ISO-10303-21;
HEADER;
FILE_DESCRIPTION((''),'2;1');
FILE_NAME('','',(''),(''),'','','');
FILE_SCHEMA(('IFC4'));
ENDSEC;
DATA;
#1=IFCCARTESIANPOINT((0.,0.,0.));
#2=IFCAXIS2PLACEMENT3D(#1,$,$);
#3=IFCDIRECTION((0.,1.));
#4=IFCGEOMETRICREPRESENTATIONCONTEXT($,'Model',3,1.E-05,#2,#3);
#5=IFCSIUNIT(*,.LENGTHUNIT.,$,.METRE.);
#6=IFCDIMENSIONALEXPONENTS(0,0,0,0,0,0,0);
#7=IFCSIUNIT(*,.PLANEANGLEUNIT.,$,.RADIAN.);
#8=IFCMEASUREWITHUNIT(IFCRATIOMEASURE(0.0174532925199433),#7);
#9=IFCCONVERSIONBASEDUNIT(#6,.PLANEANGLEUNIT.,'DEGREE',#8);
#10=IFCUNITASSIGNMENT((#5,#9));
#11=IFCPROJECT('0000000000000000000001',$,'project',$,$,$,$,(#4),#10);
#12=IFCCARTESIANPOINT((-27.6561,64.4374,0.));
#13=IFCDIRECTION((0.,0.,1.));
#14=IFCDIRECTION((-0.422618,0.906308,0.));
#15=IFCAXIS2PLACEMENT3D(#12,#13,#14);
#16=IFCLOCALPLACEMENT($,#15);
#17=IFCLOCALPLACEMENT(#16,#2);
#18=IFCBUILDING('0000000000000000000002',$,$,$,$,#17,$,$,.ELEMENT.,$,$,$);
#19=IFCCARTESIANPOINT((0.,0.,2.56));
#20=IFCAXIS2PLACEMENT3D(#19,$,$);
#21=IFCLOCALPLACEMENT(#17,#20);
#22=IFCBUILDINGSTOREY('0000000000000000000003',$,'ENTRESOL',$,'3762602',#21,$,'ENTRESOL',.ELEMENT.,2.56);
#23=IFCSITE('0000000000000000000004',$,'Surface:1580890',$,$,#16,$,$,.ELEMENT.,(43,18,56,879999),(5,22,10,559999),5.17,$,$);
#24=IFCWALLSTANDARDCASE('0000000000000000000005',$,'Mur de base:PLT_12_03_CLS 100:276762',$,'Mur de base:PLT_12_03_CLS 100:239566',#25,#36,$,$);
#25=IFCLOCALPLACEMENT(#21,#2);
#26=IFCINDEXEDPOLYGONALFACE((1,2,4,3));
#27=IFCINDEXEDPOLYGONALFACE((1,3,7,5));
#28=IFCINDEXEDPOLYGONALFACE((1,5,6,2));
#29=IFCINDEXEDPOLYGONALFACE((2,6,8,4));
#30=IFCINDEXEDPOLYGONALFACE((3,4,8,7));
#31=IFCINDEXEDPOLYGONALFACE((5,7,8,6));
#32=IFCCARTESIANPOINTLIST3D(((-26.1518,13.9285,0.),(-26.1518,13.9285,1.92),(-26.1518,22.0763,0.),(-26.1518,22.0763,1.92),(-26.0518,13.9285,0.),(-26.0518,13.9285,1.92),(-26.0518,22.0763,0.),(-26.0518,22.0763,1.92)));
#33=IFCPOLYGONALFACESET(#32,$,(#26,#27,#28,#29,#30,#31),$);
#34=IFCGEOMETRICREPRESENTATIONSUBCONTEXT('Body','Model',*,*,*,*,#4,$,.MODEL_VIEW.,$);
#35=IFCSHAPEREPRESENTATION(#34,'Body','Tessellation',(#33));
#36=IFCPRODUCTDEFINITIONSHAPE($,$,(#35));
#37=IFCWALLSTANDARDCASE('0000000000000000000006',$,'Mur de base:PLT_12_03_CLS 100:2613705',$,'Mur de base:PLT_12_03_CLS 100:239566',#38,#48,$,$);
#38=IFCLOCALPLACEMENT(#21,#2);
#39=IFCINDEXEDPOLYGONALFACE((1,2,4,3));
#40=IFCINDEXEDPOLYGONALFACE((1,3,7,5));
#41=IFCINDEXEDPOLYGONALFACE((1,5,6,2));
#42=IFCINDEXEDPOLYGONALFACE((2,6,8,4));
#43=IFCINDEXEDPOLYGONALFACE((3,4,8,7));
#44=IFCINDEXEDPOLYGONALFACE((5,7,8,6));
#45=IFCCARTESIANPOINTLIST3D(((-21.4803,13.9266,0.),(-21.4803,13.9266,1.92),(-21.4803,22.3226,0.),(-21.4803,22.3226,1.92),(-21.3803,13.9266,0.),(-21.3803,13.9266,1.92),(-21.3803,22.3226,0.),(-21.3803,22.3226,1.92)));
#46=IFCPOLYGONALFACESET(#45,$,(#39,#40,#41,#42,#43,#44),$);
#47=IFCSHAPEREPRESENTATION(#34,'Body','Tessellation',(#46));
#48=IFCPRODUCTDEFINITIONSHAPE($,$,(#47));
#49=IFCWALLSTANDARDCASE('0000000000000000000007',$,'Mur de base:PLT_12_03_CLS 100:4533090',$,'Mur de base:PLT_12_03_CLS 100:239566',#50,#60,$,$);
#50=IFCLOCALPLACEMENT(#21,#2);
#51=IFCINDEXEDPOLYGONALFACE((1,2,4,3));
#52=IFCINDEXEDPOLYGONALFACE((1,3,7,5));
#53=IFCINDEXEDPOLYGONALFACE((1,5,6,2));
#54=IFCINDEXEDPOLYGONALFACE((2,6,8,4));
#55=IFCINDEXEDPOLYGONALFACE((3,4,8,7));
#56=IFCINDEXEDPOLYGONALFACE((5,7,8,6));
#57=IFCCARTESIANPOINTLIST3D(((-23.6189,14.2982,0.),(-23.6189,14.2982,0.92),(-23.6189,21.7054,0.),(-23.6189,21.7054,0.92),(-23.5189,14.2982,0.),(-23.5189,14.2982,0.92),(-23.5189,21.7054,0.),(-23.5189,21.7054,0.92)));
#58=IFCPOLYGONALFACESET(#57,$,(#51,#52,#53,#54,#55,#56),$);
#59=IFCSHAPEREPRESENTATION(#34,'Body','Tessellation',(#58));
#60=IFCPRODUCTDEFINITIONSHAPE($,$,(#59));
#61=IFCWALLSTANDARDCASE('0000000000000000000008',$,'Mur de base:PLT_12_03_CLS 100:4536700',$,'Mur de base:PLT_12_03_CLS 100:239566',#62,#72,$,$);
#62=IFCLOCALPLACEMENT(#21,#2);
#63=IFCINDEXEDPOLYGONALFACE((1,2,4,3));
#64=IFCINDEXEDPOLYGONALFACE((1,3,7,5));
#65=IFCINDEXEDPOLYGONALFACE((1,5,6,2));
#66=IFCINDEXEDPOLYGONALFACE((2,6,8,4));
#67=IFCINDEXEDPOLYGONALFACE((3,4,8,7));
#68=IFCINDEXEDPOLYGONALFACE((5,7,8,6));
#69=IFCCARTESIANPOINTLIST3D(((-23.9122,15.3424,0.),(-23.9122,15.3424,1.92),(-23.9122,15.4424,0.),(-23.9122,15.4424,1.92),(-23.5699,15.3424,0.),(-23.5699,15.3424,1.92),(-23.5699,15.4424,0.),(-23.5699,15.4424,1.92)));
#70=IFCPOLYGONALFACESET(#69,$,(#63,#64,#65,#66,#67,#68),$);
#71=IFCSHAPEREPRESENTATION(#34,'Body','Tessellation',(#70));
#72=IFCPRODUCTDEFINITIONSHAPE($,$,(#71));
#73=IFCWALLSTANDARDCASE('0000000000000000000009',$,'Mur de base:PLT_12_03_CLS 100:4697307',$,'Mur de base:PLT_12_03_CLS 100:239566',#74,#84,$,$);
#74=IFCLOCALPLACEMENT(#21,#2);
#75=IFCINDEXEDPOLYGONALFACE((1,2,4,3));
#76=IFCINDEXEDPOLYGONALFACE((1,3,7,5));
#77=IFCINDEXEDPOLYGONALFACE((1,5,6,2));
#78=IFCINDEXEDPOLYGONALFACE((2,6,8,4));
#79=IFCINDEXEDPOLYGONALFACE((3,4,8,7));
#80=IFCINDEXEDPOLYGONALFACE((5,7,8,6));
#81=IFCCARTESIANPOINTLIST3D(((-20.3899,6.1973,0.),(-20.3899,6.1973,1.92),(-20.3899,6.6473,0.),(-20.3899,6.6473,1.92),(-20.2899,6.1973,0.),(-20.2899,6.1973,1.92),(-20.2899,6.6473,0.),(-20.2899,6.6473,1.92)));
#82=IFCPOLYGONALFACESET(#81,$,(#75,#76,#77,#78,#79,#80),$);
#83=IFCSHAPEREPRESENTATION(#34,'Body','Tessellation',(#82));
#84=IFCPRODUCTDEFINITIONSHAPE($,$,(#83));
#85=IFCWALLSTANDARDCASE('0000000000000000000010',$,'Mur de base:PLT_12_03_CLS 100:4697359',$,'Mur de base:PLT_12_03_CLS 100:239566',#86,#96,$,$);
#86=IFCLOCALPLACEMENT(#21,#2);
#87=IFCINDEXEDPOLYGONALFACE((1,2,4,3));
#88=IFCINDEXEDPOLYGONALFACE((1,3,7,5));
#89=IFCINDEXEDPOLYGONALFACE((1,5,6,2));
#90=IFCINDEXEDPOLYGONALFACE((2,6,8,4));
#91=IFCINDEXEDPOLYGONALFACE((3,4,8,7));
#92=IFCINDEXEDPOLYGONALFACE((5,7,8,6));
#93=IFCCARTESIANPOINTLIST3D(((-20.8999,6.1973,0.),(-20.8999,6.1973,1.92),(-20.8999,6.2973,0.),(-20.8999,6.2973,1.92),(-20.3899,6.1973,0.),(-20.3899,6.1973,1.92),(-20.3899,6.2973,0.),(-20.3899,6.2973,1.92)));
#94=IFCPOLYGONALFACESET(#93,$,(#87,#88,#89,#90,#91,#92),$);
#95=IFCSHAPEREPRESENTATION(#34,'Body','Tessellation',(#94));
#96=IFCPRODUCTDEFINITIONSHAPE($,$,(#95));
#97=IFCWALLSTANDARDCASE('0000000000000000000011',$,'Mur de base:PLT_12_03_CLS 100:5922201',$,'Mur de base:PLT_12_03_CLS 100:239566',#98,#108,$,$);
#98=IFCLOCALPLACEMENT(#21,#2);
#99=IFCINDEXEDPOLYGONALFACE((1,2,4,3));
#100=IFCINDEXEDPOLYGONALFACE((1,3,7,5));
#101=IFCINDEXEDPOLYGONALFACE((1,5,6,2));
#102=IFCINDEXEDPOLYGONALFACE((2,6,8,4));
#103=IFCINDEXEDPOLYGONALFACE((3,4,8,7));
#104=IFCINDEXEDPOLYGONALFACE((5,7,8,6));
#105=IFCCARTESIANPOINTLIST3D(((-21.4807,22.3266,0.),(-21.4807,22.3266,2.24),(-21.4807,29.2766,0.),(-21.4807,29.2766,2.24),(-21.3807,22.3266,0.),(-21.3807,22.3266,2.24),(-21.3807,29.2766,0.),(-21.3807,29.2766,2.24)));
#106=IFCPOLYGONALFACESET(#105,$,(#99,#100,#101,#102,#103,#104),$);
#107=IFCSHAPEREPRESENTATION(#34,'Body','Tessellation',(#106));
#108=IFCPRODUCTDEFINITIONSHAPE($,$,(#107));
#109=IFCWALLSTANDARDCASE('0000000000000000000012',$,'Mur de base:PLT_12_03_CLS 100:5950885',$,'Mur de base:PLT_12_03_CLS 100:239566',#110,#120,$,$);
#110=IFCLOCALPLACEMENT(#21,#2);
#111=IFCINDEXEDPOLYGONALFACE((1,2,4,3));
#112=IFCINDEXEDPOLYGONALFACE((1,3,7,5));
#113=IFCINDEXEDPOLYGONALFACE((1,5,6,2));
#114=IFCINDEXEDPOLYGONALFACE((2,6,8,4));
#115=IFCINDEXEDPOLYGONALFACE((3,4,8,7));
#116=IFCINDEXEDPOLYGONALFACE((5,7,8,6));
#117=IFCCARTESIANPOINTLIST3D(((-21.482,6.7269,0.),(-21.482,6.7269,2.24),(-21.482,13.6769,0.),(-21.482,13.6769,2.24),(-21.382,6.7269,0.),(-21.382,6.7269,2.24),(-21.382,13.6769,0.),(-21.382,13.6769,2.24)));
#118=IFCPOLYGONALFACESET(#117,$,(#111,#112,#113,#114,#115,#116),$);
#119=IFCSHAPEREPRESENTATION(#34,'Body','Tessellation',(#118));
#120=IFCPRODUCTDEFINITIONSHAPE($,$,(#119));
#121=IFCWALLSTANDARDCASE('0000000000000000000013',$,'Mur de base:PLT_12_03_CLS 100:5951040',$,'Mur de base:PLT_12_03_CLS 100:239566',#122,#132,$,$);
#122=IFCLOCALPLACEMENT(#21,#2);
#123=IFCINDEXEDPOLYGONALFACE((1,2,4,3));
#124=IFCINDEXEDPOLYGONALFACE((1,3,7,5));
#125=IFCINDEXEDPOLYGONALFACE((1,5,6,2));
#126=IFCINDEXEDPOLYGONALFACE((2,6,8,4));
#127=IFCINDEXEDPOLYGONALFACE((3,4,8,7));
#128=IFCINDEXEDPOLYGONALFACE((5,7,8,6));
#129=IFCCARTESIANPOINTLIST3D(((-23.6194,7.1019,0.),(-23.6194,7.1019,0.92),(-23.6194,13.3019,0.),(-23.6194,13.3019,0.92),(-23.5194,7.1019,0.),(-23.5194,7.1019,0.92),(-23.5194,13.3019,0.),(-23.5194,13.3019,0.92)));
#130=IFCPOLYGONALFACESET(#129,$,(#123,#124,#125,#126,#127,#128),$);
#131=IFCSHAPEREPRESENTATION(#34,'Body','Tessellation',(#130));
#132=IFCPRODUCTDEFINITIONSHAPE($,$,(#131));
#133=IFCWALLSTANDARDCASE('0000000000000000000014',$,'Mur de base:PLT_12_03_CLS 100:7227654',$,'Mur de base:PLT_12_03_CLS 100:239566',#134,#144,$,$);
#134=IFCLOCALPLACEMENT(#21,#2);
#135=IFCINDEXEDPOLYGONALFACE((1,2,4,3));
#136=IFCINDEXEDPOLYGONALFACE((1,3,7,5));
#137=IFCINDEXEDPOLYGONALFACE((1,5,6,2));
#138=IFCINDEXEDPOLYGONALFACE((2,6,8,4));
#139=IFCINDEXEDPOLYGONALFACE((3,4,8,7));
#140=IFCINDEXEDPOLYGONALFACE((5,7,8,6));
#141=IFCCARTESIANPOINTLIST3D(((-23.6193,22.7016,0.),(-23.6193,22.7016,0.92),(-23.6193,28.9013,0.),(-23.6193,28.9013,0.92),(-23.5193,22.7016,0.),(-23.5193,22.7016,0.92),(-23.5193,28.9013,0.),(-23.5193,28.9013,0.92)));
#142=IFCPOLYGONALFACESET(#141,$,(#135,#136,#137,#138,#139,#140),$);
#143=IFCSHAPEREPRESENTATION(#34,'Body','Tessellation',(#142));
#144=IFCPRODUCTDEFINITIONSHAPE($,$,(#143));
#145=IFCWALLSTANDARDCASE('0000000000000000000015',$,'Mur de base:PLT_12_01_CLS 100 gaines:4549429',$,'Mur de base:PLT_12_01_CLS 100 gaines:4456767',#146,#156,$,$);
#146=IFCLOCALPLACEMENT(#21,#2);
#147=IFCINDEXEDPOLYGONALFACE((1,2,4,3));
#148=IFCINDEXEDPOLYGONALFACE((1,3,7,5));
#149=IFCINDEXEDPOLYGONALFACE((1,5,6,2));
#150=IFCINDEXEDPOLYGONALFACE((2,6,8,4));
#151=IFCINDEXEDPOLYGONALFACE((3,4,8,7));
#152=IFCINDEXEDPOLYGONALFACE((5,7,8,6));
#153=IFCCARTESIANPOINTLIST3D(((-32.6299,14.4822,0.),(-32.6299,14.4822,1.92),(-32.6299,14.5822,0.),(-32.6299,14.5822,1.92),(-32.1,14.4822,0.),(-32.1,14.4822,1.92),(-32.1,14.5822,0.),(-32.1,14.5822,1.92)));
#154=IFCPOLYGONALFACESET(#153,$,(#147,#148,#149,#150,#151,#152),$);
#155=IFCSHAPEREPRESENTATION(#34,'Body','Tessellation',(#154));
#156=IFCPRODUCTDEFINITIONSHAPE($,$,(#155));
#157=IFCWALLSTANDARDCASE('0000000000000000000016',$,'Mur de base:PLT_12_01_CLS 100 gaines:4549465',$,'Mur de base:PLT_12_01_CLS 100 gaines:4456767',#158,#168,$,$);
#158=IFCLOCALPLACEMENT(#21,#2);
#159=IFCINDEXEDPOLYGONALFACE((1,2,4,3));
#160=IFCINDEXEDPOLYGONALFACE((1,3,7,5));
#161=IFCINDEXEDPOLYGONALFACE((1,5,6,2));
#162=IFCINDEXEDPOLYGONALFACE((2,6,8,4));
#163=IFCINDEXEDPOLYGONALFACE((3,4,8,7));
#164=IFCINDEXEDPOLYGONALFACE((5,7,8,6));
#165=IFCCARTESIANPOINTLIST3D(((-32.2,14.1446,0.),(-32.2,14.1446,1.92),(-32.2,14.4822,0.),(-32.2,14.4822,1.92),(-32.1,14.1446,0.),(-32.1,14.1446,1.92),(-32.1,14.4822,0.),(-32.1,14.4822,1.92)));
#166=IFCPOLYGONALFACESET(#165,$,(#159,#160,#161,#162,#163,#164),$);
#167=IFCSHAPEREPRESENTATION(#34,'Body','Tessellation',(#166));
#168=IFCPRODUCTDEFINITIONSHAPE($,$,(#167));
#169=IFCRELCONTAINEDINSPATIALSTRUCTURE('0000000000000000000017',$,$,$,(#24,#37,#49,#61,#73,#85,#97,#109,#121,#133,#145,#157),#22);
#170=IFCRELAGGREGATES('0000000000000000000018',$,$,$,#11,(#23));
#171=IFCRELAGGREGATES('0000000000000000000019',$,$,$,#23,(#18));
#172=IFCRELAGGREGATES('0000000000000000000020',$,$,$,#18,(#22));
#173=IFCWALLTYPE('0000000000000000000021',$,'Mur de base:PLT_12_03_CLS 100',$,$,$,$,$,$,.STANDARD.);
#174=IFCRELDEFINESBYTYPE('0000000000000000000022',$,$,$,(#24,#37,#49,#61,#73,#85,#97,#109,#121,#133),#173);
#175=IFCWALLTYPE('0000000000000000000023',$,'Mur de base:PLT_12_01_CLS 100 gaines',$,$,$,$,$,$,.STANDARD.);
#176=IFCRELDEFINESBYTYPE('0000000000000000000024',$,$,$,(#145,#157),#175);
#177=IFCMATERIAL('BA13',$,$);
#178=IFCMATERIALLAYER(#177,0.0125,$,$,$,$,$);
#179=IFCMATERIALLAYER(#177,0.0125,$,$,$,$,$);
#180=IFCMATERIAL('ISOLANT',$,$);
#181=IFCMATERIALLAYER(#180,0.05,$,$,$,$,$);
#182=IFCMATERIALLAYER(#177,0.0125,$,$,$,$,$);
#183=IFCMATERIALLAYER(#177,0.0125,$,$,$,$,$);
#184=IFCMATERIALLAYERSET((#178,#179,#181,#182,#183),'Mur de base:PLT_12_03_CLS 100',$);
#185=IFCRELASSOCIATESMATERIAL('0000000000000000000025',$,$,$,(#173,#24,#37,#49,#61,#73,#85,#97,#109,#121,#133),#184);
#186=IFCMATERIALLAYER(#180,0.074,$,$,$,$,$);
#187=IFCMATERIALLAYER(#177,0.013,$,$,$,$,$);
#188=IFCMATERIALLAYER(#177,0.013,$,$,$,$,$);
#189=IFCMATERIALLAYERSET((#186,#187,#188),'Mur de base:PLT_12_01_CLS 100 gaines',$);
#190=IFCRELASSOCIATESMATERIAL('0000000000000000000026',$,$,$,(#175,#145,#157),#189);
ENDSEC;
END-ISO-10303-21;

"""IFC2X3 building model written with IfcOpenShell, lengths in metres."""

from ifc_helpers import new_model, entity, si_unit, converted_unit, direction, frame, frame_2d, origin, place, context, subcontext, project, spatial, polyline, rectangle, extrude, clip, halfspace, bounded_halfspace, material, layer, layer_set, layer_usage, type_object, element, save


model = new_model("IFC2X3")

# Units and contexts
model_context = context("Model", 3, precision=1e-05, world=origin(), true_north=direction((0.0, 1.0)))
body_context = subcontext(model_context, "Body", "Model", "MODEL_VIEW")
ifc_project = project(units=[si_unit("LENGTHUNIT", "METRE"), converted_unit("PLANEANGLEUNIT", "DEGREE", entity("IfcRatioMeasure", 0.0174532925199433), si_unit("PLANEANGLEUNIT", "RADIAN"), dimensions=[0, 0, 0, 0, 0, 0, 0])], contexts=[model_context])

# Site, building, storey
site_placement = place(None, frame((-27.6561, 64.4374, 0.0), z_axis=(0.0, 0.0, 1.0), x_axis=(-0.422618, 0.906308, 0.0)))
site = spatial("IfcSite", under=ifc_project, at=site_placement, Name="Surface:1580890", CompositionType="ELEMENT", RefLatitude=(43, 18, 56, 879999), RefLongitude=(5, 22, 10, 559999), RefElevation=5.17)
building_placement = place(site_placement, origin())
building = spatial("IfcBuilding", under=site, at=building_placement, CompositionType="ELEMENT")
storey_placement = place(building_placement, frame((0.0, 0.0, 2.56)))
storey = spatial("IfcBuildingStorey", under=building, at=storey_placement, Name="ENTRESOL", ObjectType="3762602", LongName="ENTRESOL", CompositionType="ELEMENT", Elevation=2.56)

# Shared definitions
ifc_material_1 = material(Name="BA13")
ifc_layer_1 = layer(ifc_material_1, 0.0125)
ifc_layer_2 = layer(ifc_material_1, 0.0125)
ifc_material_2 = material(Name="ISOLANT")
ifc_layer_3 = layer(ifc_material_2, 0.05)
ifc_layer_4 = layer(ifc_material_1, 0.0125)
ifc_layer_5 = layer(ifc_material_1, 0.0125)
ifc_layer_set_1 = layer_set([ifc_layer_1, ifc_layer_2, ifc_layer_3, ifc_layer_4, ifc_layer_5], Name="Mur de base:PLT_12_03_CLS 100")
wall_type_1 = type_object("IfcWallType", Name="Mur de base:PLT_12_03_CLS 100", PredefinedType="STANDARD", material=ifc_layer_set_1)

# Walls
ifc_layer_usage_1 = layer_usage(ifc_layer_set_1, "AXIS2", "NEGATIVE", 0.05)
wall_1_placement = place(storey_placement, frame((-26.1018, 22.0763, 0.0), z_axis=(0.0, 0.0, 1.0), x_axis=(0.0, -1.0, 0.0)))
element("IfcWallStandardCase", 1, at=wall_1_placement, inside=storey, type_object=wall_type_1, material=ifc_layer_usage_1, Name="Mur de base:PLT_12_03_CLS 100:276762", ObjectType="Mur de base:PLT_12_03_CLS 100:239566", context=body_context, shape_type="Clipping", body=[
    clip(clip(extrude(rectangle(XDim=8.1479, YDim=0.1, at=frame_2d((4.0739, 0.0), x_axis=(-1.0, 0.0))), origin(), (0.0, 0.0, 1.0), 1.92), bounded_halfspace(frame((0.0, -0.05, 1.92), z_axis=(0.0, 0.0, -1.0), x_axis=(-1.0, 0.0, 0.0)), True, frame((0.0, -0.05, 1.92)), polyline([(0.0, 0.0), (8.1479, 0.0), (8.1479, 0.1), (0.0, 0.1), (0.0, 0.0)]))), halfspace(frame((0.0, 0.0, -2.56)), True)),
])
ifc_layer_usage_2 = layer_usage(ifc_layer_set_1, "AXIS2", "NEGATIVE", 0.05)
wall_2_placement = place(storey_placement, frame((-21.4303, 22.3226, 0.0), z_axis=(0.0, 0.0, 1.0), x_axis=(0.0, -1.0, 0.0)))
element("IfcWallStandardCase", 2, at=wall_2_placement, inside=storey, type_object=wall_type_1, material=ifc_layer_usage_2, Name="Mur de base:PLT_12_03_CLS 100:2613705", ObjectType="Mur de base:PLT_12_03_CLS 100:239566", context=body_context, shape_type="Clipping", body=[
    clip(clip(extrude(rectangle(XDim=8.396, YDim=0.1, at=frame_2d((4.198, 0.0), x_axis=(-1.0, 0.0))), origin(), (0.0, 0.0, 1.0), 1.92), bounded_halfspace(frame((0.0, -0.05, 1.92), z_axis=(0.0, 0.0, -1.0), x_axis=(-1.0, 0.0, 0.0)), True, frame((0.0, -0.05, 1.92)), polyline([(0.0, 0.0), (8.396, 0.0), (8.396, 0.1), (0.2442, 0.1), (0.0, 0.1), (0.0, 0.0)]))), halfspace(frame((0.0, 0.0, -2.56)), True)),
])
ifc_layer_usage_3 = layer_usage(ifc_layer_set_1, "AXIS2", "POSITIVE", -0.05)
wall_3_placement = place(storey_placement, frame((-23.5689, 21.7054, 0.0), z_axis=(0.0, 0.0, 1.0), x_axis=(0.0, -1.0, 0.0)))
element("IfcWallStandardCase", 3, at=wall_3_placement, inside=storey, type_object=wall_type_1, material=ifc_layer_usage_3, Name="Mur de base:PLT_12_03_CLS 100:4533090", ObjectType="Mur de base:PLT_12_03_CLS 100:239566", context=body_context, shape_type="Clipping", body=[
    clip(extrude(rectangle(XDim=7.4072, YDim=0.1, at=frame_2d((3.7036, 0.0), x_axis=(-1.0, 0.0))), origin(), (0.0, 0.0, 1.0), 0.92), halfspace(frame((0.0, 0.0, -2.56)), True)),
])
ifc_layer_usage_4 = layer_usage(ifc_layer_set_1, "AXIS2", "NEGATIVE", 0.05)
wall_4_placement = place(storey_placement, frame((-23.5699, 15.3924, 0.0), z_axis=(0.0, 0.0, 1.0), x_axis=(-1.0, 0.0, 0.0)))
element("IfcWallStandardCase", 4, at=wall_4_placement, inside=storey, type_object=wall_type_1, material=ifc_layer_usage_4, Name="Mur de base:PLT_12_03_CLS 100:4536700", ObjectType="Mur de base:PLT_12_03_CLS 100:239566", context=body_context, shape_type="Clipping", body=[
    clip(extrude(rectangle(XDim=0.3423, YDim=0.1, at=frame_2d((0.1712, 0.0), x_axis=(-1.0, 0.0))), origin(), (0.0, 0.0, 1.0), 1.92), halfspace(frame((0.0, 0.0, -2.56)), True)),
])
ifc_layer_usage_5 = layer_usage(ifc_layer_set_1, "AXIS2", "NEGATIVE", 0.05)
wall_5_placement = place(storey_placement, frame((-20.3399, 6.6473, 0.0), z_axis=(0.0, 0.0, 1.0), x_axis=(0.0, -1.0, 0.0)))
element("IfcWallStandardCase", 5, at=wall_5_placement, inside=storey, type_object=wall_type_1, material=ifc_layer_usage_5, Name="Mur de base:PLT_12_03_CLS 100:4697307", ObjectType="Mur de base:PLT_12_03_CLS 100:239566", context=body_context, shape_type="Clipping", body=[
    clip(extrude(rectangle(XDim=0.45, YDim=0.1, at=frame_2d((0.225, 0.0), x_axis=(-1.0, 0.0))), origin(), (0.0, 0.0, 1.0), 1.92), halfspace(frame((0.0, 0.0, -2.56)), True)),
])
ifc_layer_usage_6 = layer_usage(ifc_layer_set_1, "AXIS2", "NEGATIVE", 0.05)
wall_6_placement = place(storey_placement, frame((-20.3899, 6.2473, 0.0), z_axis=(0.0, 0.0, 1.0), x_axis=(-1.0, 0.0, 0.0)))
element("IfcWallStandardCase", 6, at=wall_6_placement, inside=storey, type_object=wall_type_1, material=ifc_layer_usage_6, Name="Mur de base:PLT_12_03_CLS 100:4697359", ObjectType="Mur de base:PLT_12_03_CLS 100:239566", context=body_context, shape_type="Clipping", body=[
    clip(extrude(rectangle(XDim=0.51, YDim=0.1, at=frame_2d((0.255, 0.0), x_axis=(-1.0, 0.0))), origin(), (0.0, 0.0, 1.0), 1.92), halfspace(frame((0.0, 0.0, -2.56)), True)),
])
ifc_layer_usage_7 = layer_usage(ifc_layer_set_1, "AXIS2", "NEGATIVE", 0.05)
wall_7_placement = place(storey_placement, frame((-21.4307, 29.2766, 0.0), z_axis=(0.0, 0.0, 1.0), x_axis=(0.0, -1.0, 0.0)))
element("IfcWallStandardCase", 7, at=wall_7_placement, inside=storey, type_object=wall_type_1, material=ifc_layer_usage_7, Name="Mur de base:PLT_12_03_CLS 100:5922201", ObjectType="Mur de base:PLT_12_03_CLS 100:239566", context=body_context, shape_type="Clipping", body=[
    clip(extrude(rectangle(XDim=6.95, YDim=0.1, at=frame_2d((3.475, 0.0), x_axis=(-1.0, 0.0))), origin(), (0.0, 0.0, 1.0), 2.24), halfspace(frame((0.0, 0.0, -2.56)), True)),
])
ifc_layer_usage_8 = layer_usage(ifc_layer_set_1, "AXIS2", "POSITIVE", -0.05)
wall_8_placement = place(storey_placement, frame((-21.432, 6.7269, 0.0), z_axis=(0.0, 0.0, 1.0), x_axis=(0.0, 1.0, 0.0)))
element("IfcWallStandardCase", 8, at=wall_8_placement, inside=storey, type_object=wall_type_1, material=ifc_layer_usage_8, Name="Mur de base:PLT_12_03_CLS 100:5950885", ObjectType="Mur de base:PLT_12_03_CLS 100:239566", context=body_context, shape_type="Clipping", body=[
    clip(extrude(rectangle(XDim=6.95, YDim=0.1, at=frame_2d((3.475, 0.0), x_axis=(-1.0, 0.0))), origin(), (0.0, 0.0, 1.0), 2.24), halfspace(frame((0.0, 0.0, -2.56)), True)),
])
ifc_layer_usage_9 = layer_usage(ifc_layer_set_1, "AXIS2", "NEGATIVE", 0.05)
wall_9_placement = place(storey_placement, frame((-23.5694, 7.1019, 0.0), z_axis=(0.0, 0.0, 1.0), x_axis=(0.0, 1.0, 0.0)))
element("IfcWallStandardCase", 9, at=wall_9_placement, inside=storey, type_object=wall_type_1, material=ifc_layer_usage_9, Name="Mur de base:PLT_12_03_CLS 100:5951040", ObjectType="Mur de base:PLT_12_03_CLS 100:239566", context=body_context, shape_type="Clipping", body=[
    clip(extrude(rectangle(XDim=6.2, YDim=0.1, at=frame_2d((3.1, 0.0), x_axis=(-1.0, 0.0))), origin(), (0.0, 0.0, 1.0), 0.92), halfspace(frame((0.0, 0.0, -2.56)), True)),
])
ifc_layer_usage_10 = layer_usage(ifc_layer_set_1, "AXIS2", "POSITIVE", -0.05)
wall_10_placement = place(storey_placement, frame((-23.5693, 28.9013, 0.0), z_axis=(0.0, 0.0, 1.0), x_axis=(0.0, -1.0, 0.0)))
element("IfcWallStandardCase", 10, at=wall_10_placement, inside=storey, type_object=wall_type_1, material=ifc_layer_usage_10, Name="Mur de base:PLT_12_03_CLS 100:7227654", ObjectType="Mur de base:PLT_12_03_CLS 100:239566", context=body_context, shape_type="Clipping", body=[
    clip(extrude(rectangle(XDim=6.1997, YDim=0.1, at=frame_2d((3.0999, 0.0), x_axis=(-1.0, 0.0))), origin(), (0.0, 0.0, 1.0), 0.92), halfspace(frame((0.0, 0.0, -2.56)), True)),
])
ifc_layer_6 = layer(ifc_material_2, 0.074)
ifc_layer_7 = layer(ifc_material_1, 0.013)
ifc_layer_8 = layer(ifc_material_1, 0.013)
ifc_layer_set_2 = layer_set([ifc_layer_6, ifc_layer_7, ifc_layer_8], Name="Mur de base:PLT_12_01_CLS 100 gaines")
ifc_layer_usage_11 = layer_usage(ifc_layer_set_2, "AXIS2", "POSITIVE", -0.05)
wall_type_2 = type_object("IfcWallType", Name="Mur de base:PLT_12_01_CLS 100 gaines", PredefinedType="STANDARD", material=ifc_layer_set_2)
wall_11_placement = place(storey_placement, frame((-32.6299, 14.5322, 0.0)))
element("IfcWallStandardCase", 11, at=wall_11_placement, inside=storey, type_object=wall_type_2, material=ifc_layer_usage_11, Name="Mur de base:PLT_12_01_CLS 100 gaines:4549429", ObjectType="Mur de base:PLT_12_01_CLS 100 gaines:4456767", context=body_context, shape_type="Clipping", body=[
    clip(extrude(rectangle(XDim=0.5299, YDim=0.1, at=frame_2d((0.2649, 0.0), x_axis=(-1.0, 0.0))), origin(), (0.0, 0.0, 1.0), 1.92), halfspace(frame((0.0, 0.0, -2.56)), True)),
])
ifc_layer_usage_12 = layer_usage(ifc_layer_set_2, "AXIS2", "POSITIVE", -0.05)
wall_12_placement = place(storey_placement, frame((-32.15, 14.4822, 0.0), z_axis=(0.0, 0.0, 1.0), x_axis=(0.0, -1.0, 0.0)))
element("IfcWallStandardCase", 12, at=wall_12_placement, inside=storey, type_object=wall_type_2, material=ifc_layer_usage_12, Name="Mur de base:PLT_12_01_CLS 100 gaines:4549465", ObjectType="Mur de base:PLT_12_01_CLS 100 gaines:4456767", context=body_context, shape_type="Clipping", body=[
    clip(extrude(rectangle(XDim=0.3376, YDim=0.1, at=frame_2d((0.1688, 0.0), x_axis=(-1.0, 0.0))), origin(), (0.0, 0.0, 1.0), 1.92), halfspace(frame((0.0, 0.0, -2.56)), True)),
])

save(model, "model.ifc")
